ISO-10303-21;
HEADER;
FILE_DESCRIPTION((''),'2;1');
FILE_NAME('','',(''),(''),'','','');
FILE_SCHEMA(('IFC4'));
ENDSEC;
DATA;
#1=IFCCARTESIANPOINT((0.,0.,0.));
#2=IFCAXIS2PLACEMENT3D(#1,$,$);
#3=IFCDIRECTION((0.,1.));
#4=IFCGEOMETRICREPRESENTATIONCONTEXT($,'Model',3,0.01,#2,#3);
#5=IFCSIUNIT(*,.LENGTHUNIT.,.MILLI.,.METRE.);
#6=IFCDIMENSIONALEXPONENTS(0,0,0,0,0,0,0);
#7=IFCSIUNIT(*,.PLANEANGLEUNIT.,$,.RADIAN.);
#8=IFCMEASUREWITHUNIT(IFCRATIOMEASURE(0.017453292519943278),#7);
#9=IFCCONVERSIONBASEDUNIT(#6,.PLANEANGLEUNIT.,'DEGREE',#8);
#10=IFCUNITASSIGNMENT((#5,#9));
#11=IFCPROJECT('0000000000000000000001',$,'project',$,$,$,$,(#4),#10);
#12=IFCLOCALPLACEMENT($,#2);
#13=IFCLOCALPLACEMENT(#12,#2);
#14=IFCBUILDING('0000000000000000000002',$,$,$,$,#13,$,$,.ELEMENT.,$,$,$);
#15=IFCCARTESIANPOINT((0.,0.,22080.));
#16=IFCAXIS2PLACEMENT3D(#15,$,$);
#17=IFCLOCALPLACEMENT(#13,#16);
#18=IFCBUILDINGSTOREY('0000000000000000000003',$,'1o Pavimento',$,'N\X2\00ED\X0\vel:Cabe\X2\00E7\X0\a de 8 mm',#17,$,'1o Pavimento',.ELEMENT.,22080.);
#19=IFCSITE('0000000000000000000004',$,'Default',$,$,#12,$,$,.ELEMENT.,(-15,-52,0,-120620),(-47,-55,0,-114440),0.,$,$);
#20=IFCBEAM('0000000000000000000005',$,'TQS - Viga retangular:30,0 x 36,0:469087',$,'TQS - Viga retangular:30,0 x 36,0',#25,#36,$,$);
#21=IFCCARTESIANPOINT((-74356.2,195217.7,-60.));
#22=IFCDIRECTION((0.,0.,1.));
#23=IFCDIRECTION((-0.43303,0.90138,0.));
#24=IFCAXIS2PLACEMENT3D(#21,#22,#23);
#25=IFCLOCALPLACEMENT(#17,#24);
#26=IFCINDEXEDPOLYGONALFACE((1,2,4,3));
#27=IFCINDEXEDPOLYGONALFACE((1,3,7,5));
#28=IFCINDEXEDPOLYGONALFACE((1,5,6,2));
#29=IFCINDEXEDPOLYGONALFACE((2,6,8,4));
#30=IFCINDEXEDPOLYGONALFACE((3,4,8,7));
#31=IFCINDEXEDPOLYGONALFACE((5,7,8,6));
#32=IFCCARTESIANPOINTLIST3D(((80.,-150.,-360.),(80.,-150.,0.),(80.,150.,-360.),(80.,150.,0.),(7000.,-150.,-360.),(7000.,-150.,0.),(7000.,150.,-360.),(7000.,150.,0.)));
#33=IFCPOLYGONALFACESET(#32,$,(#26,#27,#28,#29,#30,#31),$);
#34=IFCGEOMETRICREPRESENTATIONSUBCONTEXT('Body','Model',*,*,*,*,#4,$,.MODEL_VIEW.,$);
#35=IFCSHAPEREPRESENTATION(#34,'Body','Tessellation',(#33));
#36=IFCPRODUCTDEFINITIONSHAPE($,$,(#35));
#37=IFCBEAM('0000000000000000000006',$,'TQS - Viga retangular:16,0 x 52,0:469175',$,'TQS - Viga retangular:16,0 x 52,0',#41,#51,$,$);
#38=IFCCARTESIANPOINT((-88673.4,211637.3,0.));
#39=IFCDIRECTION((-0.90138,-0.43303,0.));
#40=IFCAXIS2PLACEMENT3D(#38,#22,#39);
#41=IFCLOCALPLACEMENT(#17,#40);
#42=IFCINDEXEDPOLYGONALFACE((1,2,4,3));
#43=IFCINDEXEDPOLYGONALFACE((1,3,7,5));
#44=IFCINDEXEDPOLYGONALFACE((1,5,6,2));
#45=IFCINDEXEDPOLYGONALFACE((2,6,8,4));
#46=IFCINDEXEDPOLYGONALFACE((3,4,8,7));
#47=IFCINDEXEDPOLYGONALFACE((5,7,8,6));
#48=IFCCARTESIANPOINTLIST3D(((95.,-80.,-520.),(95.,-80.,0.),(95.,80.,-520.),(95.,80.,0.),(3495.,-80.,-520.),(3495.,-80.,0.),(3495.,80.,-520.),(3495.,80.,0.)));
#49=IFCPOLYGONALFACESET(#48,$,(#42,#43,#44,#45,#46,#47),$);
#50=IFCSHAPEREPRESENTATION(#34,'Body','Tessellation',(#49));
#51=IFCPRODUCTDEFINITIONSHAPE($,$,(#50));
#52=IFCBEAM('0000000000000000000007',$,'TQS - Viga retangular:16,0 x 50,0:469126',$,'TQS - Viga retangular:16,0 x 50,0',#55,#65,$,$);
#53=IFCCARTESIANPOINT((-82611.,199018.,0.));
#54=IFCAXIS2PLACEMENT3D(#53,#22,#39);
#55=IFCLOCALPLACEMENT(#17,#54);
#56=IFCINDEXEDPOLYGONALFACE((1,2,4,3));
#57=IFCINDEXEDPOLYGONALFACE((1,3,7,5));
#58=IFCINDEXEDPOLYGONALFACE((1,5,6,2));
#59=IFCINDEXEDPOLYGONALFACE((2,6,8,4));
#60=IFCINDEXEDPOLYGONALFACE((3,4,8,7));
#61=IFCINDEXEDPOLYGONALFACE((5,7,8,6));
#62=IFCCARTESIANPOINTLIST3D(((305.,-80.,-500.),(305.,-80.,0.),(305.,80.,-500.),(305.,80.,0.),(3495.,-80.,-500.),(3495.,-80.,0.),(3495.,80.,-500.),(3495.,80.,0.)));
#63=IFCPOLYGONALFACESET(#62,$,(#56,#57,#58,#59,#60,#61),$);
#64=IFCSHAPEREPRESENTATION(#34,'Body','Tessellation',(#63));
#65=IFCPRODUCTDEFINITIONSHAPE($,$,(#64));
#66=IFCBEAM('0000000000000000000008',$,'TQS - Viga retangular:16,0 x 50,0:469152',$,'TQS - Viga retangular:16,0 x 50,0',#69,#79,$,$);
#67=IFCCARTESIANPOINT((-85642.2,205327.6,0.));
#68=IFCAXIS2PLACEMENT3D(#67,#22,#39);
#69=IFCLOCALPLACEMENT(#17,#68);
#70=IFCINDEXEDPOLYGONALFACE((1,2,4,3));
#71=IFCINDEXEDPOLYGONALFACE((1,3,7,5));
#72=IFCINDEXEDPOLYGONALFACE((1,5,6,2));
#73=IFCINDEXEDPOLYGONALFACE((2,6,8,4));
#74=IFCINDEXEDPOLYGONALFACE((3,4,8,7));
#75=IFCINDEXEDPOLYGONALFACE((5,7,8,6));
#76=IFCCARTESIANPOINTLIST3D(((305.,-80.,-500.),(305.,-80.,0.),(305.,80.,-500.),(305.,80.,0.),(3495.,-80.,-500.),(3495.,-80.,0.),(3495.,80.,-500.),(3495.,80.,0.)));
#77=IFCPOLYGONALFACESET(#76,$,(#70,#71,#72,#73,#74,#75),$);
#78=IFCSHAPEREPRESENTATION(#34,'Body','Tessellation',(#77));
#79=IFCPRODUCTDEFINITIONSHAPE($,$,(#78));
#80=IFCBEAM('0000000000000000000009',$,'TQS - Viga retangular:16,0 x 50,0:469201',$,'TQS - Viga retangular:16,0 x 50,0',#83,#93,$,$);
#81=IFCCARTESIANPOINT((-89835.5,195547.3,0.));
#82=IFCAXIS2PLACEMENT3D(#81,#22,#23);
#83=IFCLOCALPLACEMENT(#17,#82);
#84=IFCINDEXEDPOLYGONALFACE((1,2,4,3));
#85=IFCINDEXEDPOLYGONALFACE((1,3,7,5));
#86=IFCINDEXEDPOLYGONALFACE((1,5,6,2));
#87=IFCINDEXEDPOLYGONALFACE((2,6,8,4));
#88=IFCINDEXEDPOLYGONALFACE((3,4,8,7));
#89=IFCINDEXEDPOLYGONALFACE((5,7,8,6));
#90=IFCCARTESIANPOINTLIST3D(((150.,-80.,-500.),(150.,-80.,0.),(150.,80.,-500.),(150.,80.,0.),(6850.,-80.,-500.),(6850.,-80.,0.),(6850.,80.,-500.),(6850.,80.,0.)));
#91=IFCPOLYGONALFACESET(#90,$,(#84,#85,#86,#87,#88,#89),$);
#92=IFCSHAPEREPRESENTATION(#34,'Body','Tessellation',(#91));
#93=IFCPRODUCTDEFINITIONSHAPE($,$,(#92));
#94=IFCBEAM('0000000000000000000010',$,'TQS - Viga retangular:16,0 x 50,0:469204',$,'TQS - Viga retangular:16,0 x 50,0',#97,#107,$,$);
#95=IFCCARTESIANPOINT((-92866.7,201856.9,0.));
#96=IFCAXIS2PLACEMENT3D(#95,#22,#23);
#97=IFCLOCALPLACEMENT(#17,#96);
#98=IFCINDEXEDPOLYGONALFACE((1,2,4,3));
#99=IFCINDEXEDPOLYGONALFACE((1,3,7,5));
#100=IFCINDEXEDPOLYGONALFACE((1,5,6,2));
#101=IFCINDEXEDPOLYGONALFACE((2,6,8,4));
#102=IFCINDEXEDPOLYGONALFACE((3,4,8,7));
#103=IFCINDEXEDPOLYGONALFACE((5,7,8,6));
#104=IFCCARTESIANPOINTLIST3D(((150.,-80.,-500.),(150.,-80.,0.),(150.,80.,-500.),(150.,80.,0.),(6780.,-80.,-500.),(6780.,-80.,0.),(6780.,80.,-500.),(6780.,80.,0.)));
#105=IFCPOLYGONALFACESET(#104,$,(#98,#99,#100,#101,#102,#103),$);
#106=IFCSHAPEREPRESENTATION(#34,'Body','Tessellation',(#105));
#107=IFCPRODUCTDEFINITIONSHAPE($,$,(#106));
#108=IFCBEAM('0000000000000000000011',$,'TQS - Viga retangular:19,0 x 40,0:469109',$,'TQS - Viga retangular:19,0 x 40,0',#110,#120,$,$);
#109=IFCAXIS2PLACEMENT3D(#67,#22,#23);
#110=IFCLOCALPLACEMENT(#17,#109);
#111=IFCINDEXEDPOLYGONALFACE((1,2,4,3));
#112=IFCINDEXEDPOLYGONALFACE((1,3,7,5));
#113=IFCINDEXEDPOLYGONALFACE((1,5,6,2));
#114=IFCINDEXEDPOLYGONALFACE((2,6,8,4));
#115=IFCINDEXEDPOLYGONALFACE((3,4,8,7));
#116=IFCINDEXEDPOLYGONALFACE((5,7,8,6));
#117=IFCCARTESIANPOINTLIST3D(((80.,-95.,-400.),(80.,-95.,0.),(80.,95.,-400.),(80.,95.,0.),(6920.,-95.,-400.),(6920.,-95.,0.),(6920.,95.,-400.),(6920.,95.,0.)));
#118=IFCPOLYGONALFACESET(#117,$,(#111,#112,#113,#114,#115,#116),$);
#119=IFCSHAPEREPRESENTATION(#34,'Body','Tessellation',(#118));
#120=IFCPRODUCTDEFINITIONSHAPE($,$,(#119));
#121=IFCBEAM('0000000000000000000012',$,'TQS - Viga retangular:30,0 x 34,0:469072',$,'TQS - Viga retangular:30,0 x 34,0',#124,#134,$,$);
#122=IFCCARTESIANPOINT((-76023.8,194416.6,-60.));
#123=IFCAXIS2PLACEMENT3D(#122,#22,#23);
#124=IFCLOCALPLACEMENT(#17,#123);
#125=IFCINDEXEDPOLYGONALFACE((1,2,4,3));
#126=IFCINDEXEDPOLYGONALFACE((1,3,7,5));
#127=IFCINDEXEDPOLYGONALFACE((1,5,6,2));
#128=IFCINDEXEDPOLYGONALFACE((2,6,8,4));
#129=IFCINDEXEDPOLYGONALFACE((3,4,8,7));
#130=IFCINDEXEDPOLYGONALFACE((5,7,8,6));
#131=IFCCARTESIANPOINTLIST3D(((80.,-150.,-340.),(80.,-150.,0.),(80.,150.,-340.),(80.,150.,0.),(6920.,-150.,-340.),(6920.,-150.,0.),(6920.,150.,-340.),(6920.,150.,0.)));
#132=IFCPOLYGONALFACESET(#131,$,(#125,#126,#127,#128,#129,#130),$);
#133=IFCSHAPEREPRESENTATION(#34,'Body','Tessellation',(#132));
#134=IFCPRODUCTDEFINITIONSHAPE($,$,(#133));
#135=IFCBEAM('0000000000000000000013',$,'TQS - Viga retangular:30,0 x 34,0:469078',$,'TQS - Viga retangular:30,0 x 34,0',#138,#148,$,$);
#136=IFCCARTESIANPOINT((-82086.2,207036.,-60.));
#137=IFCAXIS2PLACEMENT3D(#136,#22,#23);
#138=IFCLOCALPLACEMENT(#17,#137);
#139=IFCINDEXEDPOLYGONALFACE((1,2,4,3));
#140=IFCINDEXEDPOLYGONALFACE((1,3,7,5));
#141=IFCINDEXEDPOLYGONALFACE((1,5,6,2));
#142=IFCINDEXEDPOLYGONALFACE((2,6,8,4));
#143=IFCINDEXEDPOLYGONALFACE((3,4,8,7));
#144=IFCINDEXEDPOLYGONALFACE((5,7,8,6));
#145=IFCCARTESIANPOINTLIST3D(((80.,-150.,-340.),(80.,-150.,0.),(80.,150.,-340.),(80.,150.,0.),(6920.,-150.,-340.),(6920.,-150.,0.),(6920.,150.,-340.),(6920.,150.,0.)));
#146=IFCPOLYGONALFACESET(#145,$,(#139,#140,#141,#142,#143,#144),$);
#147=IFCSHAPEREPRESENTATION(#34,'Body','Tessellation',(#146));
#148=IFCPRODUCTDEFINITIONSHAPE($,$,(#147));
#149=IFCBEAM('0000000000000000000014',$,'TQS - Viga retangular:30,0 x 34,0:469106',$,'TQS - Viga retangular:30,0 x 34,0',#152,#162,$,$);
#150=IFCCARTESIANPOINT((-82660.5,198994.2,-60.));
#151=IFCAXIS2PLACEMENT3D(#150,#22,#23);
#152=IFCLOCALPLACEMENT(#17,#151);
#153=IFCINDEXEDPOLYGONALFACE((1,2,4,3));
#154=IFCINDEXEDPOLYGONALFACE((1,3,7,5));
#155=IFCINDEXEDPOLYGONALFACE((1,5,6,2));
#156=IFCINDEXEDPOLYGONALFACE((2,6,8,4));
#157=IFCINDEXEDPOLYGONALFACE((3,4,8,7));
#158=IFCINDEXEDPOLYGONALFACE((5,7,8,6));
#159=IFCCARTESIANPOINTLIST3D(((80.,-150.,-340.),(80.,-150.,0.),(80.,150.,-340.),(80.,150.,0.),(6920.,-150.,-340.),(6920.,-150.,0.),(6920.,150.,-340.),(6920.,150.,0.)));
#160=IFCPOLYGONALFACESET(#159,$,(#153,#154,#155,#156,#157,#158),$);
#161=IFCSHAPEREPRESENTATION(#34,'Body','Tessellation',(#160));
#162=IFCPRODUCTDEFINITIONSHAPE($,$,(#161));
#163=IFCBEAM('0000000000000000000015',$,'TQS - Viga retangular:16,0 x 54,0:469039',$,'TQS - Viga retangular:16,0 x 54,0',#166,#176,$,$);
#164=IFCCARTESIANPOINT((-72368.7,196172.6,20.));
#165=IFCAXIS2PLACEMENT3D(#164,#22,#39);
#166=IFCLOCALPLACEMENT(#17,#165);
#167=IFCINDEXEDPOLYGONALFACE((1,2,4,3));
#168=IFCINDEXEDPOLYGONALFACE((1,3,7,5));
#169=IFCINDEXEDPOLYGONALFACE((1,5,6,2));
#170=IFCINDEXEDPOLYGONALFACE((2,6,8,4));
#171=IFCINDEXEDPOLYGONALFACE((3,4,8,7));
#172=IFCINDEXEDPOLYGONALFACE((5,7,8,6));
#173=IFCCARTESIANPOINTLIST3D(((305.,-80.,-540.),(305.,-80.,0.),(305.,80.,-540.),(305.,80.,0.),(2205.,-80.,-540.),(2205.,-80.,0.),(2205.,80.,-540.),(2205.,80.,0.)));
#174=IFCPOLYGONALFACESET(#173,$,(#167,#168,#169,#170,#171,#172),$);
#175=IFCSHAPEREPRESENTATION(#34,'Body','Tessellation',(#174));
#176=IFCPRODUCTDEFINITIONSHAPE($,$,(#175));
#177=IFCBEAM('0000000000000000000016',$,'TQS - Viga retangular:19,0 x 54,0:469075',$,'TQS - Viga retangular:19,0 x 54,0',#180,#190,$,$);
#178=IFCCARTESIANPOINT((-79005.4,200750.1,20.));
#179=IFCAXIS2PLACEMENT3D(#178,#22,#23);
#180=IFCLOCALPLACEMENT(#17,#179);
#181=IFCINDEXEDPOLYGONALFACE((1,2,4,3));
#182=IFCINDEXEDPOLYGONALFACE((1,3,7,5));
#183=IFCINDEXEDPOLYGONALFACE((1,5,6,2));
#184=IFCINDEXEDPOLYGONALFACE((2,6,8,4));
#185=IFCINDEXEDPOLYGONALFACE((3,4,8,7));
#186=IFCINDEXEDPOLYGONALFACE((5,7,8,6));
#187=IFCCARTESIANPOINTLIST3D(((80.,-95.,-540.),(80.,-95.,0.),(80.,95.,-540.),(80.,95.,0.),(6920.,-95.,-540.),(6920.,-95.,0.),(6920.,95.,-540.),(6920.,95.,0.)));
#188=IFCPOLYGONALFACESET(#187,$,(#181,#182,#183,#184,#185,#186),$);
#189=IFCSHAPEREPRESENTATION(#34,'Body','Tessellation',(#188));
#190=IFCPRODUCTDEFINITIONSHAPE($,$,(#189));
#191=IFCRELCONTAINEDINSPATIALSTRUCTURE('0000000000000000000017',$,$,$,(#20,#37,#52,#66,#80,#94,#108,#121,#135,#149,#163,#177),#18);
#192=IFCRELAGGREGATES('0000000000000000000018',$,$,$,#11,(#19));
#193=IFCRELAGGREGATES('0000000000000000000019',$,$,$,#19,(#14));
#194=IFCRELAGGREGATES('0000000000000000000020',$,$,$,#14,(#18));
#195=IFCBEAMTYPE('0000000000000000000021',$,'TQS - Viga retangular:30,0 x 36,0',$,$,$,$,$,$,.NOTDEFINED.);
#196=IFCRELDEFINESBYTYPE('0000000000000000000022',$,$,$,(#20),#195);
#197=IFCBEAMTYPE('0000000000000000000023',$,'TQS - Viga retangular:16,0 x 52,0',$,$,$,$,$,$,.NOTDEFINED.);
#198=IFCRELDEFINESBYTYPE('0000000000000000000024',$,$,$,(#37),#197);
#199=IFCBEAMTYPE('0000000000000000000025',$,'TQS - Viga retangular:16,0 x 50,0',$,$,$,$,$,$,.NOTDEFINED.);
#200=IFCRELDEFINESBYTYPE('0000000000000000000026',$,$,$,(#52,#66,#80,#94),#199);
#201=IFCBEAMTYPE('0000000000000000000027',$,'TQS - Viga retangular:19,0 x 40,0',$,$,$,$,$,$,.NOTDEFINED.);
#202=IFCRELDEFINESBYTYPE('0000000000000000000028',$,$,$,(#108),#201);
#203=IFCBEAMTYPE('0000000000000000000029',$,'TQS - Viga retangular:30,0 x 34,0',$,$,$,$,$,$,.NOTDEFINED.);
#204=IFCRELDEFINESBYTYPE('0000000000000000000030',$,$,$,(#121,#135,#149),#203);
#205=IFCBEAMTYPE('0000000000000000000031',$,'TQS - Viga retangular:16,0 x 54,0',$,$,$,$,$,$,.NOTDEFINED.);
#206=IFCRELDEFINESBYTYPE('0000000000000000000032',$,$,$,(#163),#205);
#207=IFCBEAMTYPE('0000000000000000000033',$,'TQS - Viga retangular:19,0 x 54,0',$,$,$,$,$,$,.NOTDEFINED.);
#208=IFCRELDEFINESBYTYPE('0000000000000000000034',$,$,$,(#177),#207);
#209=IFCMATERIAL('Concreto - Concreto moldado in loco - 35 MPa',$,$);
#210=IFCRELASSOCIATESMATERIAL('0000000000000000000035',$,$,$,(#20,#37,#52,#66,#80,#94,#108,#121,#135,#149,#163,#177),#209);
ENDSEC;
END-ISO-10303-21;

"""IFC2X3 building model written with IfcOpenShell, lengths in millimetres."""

from ifc_helpers import new_model, entity, si_unit, converted_unit, direction, frame, frame_2d, origin, origin_2d_with_axis, place, context, subcontext, project, spatial, rectangle, extrude, material, type_object, element, save


model = new_model("IFC2X3")

# Units and contexts
model_context = context("Model", 3, precision=0.01, world=origin(), true_north=direction((0.0, 1.0)))
body_context = subcontext(model_context, "Body", "Model", "MODEL_VIEW")
ifc_project = project(units=[si_unit("LENGTHUNIT", "METRE", prefix="MILLI"), converted_unit("PLANEANGLEUNIT", "DEGREE", entity("IfcRatioMeasure", 0.017453292519943278), si_unit("PLANEANGLEUNIT", "RADIAN"), dimensions=[0, 0, 0, 0, 0, 0, 0])], contexts=[model_context])

# Site, building, storey
site_placement = place(None, origin())
site = spatial("IfcSite", under=ifc_project, at=site_placement, Name="Default", CompositionType="ELEMENT", RefLatitude=(-15, -52, 0, -120620), RefLongitude=(-47, -55, 0, -114440), RefElevation=0.0)
building_placement = place(site_placement, origin())
building = spatial("IfcBuilding", under=site, at=building_placement, CompositionType="ELEMENT")
storey_placement = place(building_placement, frame((0.0, 0.0, 22080.0)))
storey = spatial("IfcBuildingStorey", under=building, at=storey_placement, Name="1o Pavimento", ObjectType="Nível:Cabeça de 8 mm", LongName="1o Pavimento", CompositionType="ELEMENT", Elevation=22080.0)

# Beams
ifc_material_1 = material(Name="Concreto - Concreto moldado in loco - 35 MPa")
beam_type_1 = type_object("IfcBeamType", Name="TQS - Viga retangular:30,0 x 36,0", PredefinedType="NOTDEFINED")
beam_1_placement = place(storey_placement, frame((-74356.2, 195217.7, -60.0), z_axis=(0.0, 0.0, 1.0), x_axis=(-0.43303, 0.90138, 0.0)))
element("IfcBeam", 1, at=beam_1_placement, inside=storey, type_object=beam_type_1, material=ifc_material_1, Name="TQS - Viga retangular:30,0 x 36,0:469087", ObjectType="TQS - Viga retangular:30,0 x 36,0", context=body_context, shape_type="SweptSolid", body=[
    extrude(rectangle(XDim=360.0, YDim=300.0, at=frame_2d((0.0, 0.0), x_axis=(1.0, 0.0))), frame((80.0, 0.0, -180.0), z_axis=(1.0, 0.0, 0.0), x_axis=(0.0, 0.0, -1.0)), (0.0, 0.0, 1.0), 6920.0),
])
beam_type_2 = type_object("IfcBeamType", Name="TQS - Viga retangular:16,0 x 52,0", PredefinedType="NOTDEFINED")
beam_2_placement = place(storey_placement, frame((-88673.4, 211637.3, 0.0), z_axis=(0.0, 0.0, 1.0), x_axis=(-0.90138, -0.43303, 0.0)))
element("IfcBeam", 2, at=beam_2_placement, inside=storey, type_object=beam_type_2, material=ifc_material_1, Name="TQS - Viga retangular:16,0 x 52,0:469175", ObjectType="TQS - Viga retangular:16,0 x 52,0", context=body_context, shape_type="SweptSolid", body=[
    extrude(rectangle(XDim=520.0, YDim=160.0, at=frame_2d((0.0, 0.0), x_axis=(1.0, 0.0))), frame((95.0, 0.0, -260.0), z_axis=(1.0, 0.0, 0.0), x_axis=(0.0, 0.0, -1.0)), (0.0, 0.0, 1.0), 3400.0),
])
beam_type_3 = type_object("IfcBeamType", Name="TQS - Viga retangular:16,0 x 50,0", PredefinedType="NOTDEFINED")
beam_3_placement = place(storey_placement, frame((-82611.0, 199018.0, 0.0), z_axis=(0.0, 0.0, 1.0), x_axis=(-0.90138, -0.43303, 0.0)))
element("IfcBeam", 3, at=beam_3_placement, inside=storey, type_object=beam_type_3, material=ifc_material_1, Name="TQS - Viga retangular:16,0 x 50,0:469126", ObjectType="TQS - Viga retangular:16,0 x 50,0", context=body_context, shape_type="SweptSolid", body=[
    extrude(rectangle(XDim=500.0, YDim=160.0, at=frame_2d((0.0, 0.0), x_axis=(1.0, 0.0))), frame((305.0, 0.0, -250.0), z_axis=(1.0, 0.0, 0.0), x_axis=(0.0, 0.0, -1.0)), (0.0, 0.0, 1.0), 3190.0),
])
beam_4_placement = place(storey_placement, frame((-85642.2, 205327.6, 0.0), z_axis=(0.0, 0.0, 1.0), x_axis=(-0.90138, -0.43303, 0.0)))
element("IfcBeam", 4, at=beam_4_placement, inside=storey, type_object=beam_type_3, material=ifc_material_1, Name="TQS - Viga retangular:16,0 x 50,0:469152", ObjectType="TQS - Viga retangular:16,0 x 50,0", context=body_context, shape_type="SweptSolid", body=[
    extrude(rectangle(XDim=500.0, YDim=160.0, at=frame_2d((0.0, 0.0), x_axis=(1.0, 0.0))), frame((305.0, 0.0, -250.0), z_axis=(1.0, 0.0, 0.0), x_axis=(0.0, 0.0, -1.0)), (0.0, 0.0, 1.0), 3190.0),
])
beam_5_placement = place(storey_placement, frame((-89835.5, 195547.3, 0.0), z_axis=(0.0, 0.0, 1.0), x_axis=(-0.43303, 0.90138, 0.0)))
element("IfcBeam", 5, at=beam_5_placement, inside=storey, type_object=beam_type_3, material=ifc_material_1, Name="TQS - Viga retangular:16,0 x 50,0:469201", ObjectType="TQS - Viga retangular:16,0 x 50,0", context=body_context, shape_type="SweptSolid", body=[
    extrude(rectangle(XDim=500.0, YDim=160.0, at=frame_2d((0.0, 0.0), x_axis=(1.0, 0.0))), frame((150.0, 0.0, -250.0), z_axis=(1.0, 0.0, 0.0), x_axis=(0.0, 0.0, -1.0)), (0.0, 0.0, 1.0), 6700.0),
])
beam_6_placement = place(storey_placement, frame((-92866.7, 201856.9, 0.0), z_axis=(0.0, 0.0, 1.0), x_axis=(-0.43303, 0.90138, 0.0)))
element("IfcBeam", 6, at=beam_6_placement, inside=storey, type_object=beam_type_3, material=ifc_material_1, Name="TQS - Viga retangular:16,0 x 50,0:469204", ObjectType="TQS - Viga retangular:16,0 x 50,0", context=body_context, shape_type="SweptSolid", body=[
    extrude(rectangle(XDim=500.0, YDim=160.0, at=origin_2d_with_axis()), frame((150.0, 0.0, -250.0), z_axis=(1.0, 0.0, 0.0), x_axis=(0.0, 0.0, -1.0)), (0.0, 0.0, 1.0), 6630.0),
])
beam_type_4 = type_object("IfcBeamType", Name="TQS - Viga retangular:19,0 x 40,0", PredefinedType="NOTDEFINED")
beam_7_placement = place(storey_placement, frame((-85642.2, 205327.6, 0.0), z_axis=(0.0, 0.0, 1.0), x_axis=(-0.43303, 0.90138, 0.0)))
element("IfcBeam", 7, at=beam_7_placement, inside=storey, type_object=beam_type_4, material=ifc_material_1, Name="TQS - Viga retangular:19,0 x 40,0:469109", ObjectType="TQS - Viga retangular:19,0 x 40,0", context=body_context, shape_type="SweptSolid", body=[
    extrude(rectangle(XDim=400.0, YDim=190.0, at=frame_2d((0.0, 0.0), x_axis=(1.0, 0.0))), frame((80.0, 0.0, -200.0), z_axis=(1.0, 0.0, 0.0), x_axis=(0.0, 0.0, -1.0)), (0.0, 0.0, 1.0), 6840.0),
])
beam_type_5 = type_object("IfcBeamType", Name="TQS - Viga retangular:30,0 x 34,0", PredefinedType="NOTDEFINED")
beam_8_placement = place(storey_placement, frame((-76023.8, 194416.6, -60.0), z_axis=(0.0, 0.0, 1.0), x_axis=(-0.43303, 0.90138, 0.0)))
element("IfcBeam", 8, at=beam_8_placement, inside=storey, type_object=beam_type_5, material=ifc_material_1, Name="TQS - Viga retangular:30,0 x 34,0:469072", ObjectType="TQS - Viga retangular:30,0 x 34,0", context=body_context, shape_type="SweptSolid", body=[
    extrude(rectangle(XDim=340.0, YDim=300.0, at=frame_2d((0.0, 0.0), x_axis=(1.0, 0.0))), frame((80.0, 0.0, -170.0), z_axis=(1.0, 0.0, 0.0), x_axis=(0.0, 0.0, -1.0)), (0.0, 0.0, 1.0), 6840.0),
])
beam_9_placement = place(storey_placement, frame((-82086.2, 207036.0, -60.0), z_axis=(0.0, 0.0, 1.0), x_axis=(-0.43303, 0.90138, 0.0)))
element("IfcBeam", 9, at=beam_9_placement, inside=storey, type_object=beam_type_5, material=ifc_material_1, Name="TQS - Viga retangular:30,0 x 34,0:469078", ObjectType="TQS - Viga retangular:30,0 x 34,0", context=body_context, shape_type="SweptSolid", body=[
    extrude(rectangle(XDim=340.0, YDim=300.0, at=frame_2d((0.0, 0.0), x_axis=(1.0, 0.0))), frame((80.0, 0.0, -170.0), z_axis=(1.0, 0.0, 0.0), x_axis=(0.0, 0.0, -1.0)), (0.0, 0.0, 1.0), 6840.0),
])
beam_10_placement = place(storey_placement, frame((-82660.5, 198994.2, -60.0), z_axis=(0.0, 0.0, 1.0), x_axis=(-0.43303, 0.90138, 0.0)))
element("IfcBeam", 10, at=beam_10_placement, inside=storey, type_object=beam_type_5, material=ifc_material_1, Name="TQS - Viga retangular:30,0 x 34,0:469106", ObjectType="TQS - Viga retangular:30,0 x 34,0", context=body_context, shape_type="SweptSolid", body=[
    extrude(rectangle(XDim=340.0, YDim=300.0, at=frame_2d((0.0, 0.0), x_axis=(1.0, 0.0))), frame((80.0, 0.0, -170.0), z_axis=(1.0, 0.0, 0.0), x_axis=(0.0, 0.0, -1.0)), (0.0, 0.0, 1.0), 6840.0),
])
beam_type_6 = type_object("IfcBeamType", Name="TQS - Viga retangular:16,0 x 54,0", PredefinedType="NOTDEFINED")
beam_11_placement = place(storey_placement, frame((-72368.7, 196172.6, 20.0), z_axis=(0.0, 0.0, 1.0), x_axis=(-0.90138, -0.43303, 0.0)))
element("IfcBeam", 11, at=beam_11_placement, inside=storey, type_object=beam_type_6, material=ifc_material_1, Name="TQS - Viga retangular:16,0 x 54,0:469039", ObjectType="TQS - Viga retangular:16,0 x 54,0", context=body_context, shape_type="SweptSolid", body=[
    extrude(rectangle(XDim=540.0, YDim=160.0, at=frame_2d((0.0, 0.0), x_axis=(1.0, 0.0))), frame((305.0, 0.0, -270.0), z_axis=(1.0, 0.0, 0.0), x_axis=(0.0, 0.0, -1.0)), (0.0, 0.0, 1.0), 1900.0),
])
beam_type_7 = type_object("IfcBeamType", Name="TQS - Viga retangular:19,0 x 54,0", PredefinedType="NOTDEFINED")
beam_12_placement = place(storey_placement, frame((-79005.4, 200750.1, 20.0), z_axis=(0.0, 0.0, 1.0), x_axis=(-0.43303, 0.90138, 0.0)))
element("IfcBeam", 12, at=beam_12_placement, inside=storey, type_object=beam_type_7, material=ifc_material_1, Name="TQS - Viga retangular:19,0 x 54,0:469075", ObjectType="TQS - Viga retangular:19,0 x 54,0", context=body_context, shape_type="SweptSolid", body=[
    extrude(rectangle(XDim=540.0, YDim=190.0, at=frame_2d((0.0, 0.0), x_axis=(1.0, 0.0))), frame((80.0, 0.0, -270.0), z_axis=(1.0, 0.0, 0.0), x_axis=(0.0, 0.0, -1.0)), (0.0, 0.0, 1.0), 6840.0),
])

save(model, "model.ifc")
